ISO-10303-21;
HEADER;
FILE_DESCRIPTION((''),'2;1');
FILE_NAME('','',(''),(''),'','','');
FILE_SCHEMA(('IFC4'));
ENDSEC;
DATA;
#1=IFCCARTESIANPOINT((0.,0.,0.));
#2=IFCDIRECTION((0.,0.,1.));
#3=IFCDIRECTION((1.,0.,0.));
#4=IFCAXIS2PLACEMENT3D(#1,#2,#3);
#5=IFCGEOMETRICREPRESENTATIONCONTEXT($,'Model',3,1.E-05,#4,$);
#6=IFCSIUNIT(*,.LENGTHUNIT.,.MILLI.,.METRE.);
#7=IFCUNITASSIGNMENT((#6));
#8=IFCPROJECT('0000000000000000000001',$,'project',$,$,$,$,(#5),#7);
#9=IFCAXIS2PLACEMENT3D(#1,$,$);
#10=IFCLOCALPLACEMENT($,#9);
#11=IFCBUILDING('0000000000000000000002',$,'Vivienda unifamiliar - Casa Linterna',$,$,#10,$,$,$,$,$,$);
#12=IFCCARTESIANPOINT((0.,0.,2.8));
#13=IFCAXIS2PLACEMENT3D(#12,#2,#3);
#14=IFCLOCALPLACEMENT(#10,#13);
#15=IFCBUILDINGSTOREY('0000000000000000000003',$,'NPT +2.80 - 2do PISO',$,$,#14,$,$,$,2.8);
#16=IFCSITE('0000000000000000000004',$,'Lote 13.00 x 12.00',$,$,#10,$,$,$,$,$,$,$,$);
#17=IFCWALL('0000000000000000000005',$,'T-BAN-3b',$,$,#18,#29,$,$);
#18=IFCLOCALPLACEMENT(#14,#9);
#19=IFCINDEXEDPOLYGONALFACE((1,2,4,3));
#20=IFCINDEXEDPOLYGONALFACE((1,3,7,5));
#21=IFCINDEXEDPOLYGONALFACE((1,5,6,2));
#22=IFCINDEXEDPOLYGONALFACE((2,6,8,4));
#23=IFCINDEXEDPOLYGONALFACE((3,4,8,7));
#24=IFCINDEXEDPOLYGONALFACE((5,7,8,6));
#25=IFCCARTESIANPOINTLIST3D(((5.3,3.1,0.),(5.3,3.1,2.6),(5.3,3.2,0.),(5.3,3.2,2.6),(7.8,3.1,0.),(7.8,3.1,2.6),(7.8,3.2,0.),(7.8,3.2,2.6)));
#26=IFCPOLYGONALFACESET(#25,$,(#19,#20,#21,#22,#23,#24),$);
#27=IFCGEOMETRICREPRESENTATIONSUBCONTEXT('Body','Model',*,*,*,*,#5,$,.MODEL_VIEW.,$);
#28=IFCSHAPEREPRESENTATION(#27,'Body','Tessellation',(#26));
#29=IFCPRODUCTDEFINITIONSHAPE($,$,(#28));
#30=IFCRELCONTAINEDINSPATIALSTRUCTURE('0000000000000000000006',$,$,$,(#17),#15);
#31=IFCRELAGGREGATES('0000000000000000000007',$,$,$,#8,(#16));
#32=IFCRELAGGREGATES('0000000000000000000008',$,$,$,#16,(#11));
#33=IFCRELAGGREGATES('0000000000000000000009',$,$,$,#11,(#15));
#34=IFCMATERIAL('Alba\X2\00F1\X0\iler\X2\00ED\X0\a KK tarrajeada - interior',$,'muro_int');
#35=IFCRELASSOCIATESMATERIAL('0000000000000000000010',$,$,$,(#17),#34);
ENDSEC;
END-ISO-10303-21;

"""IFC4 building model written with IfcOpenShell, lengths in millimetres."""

from ifc_helpers import new_model, si_unit, frame, origin, origin_with_axes, place, context, subcontext, project, spatial, polyline, outline, extrude, material, element, save


model = new_model("IFC4")

# Units and contexts
model_context = context("Model", 3, precision=1e-05, world=origin_with_axes())
body_context = subcontext(model_context, "Body", "Model", "MODEL_VIEW")
ifc_project = project(units=[si_unit("LENGTHUNIT", "METRE", prefix="MILLI")], contexts=[model_context])

# Site, building, storey
placement = place(None, origin())
site = spatial("IfcSite", under=ifc_project, at=placement, Name="Lote 13.00 x 12.00")
building = spatial("IfcBuilding", under=site, at=placement, Name="Vivienda unifamiliar - Casa Linterna")
storey_placement = place(placement, frame((0.0, 0.0, 2.8), z_axis=(0.0, 0.0, 1.0), x_axis=(1.0, 0.0, 0.0)))
storey = spatial("IfcBuildingStorey", under=building, at=storey_placement, Name="NPT +2.80 - 2do PISO", Elevation=2.8)

# Shared definitions
ifc_material_1 = material(Name="Albañilería KK tarrajeada - interior", Category="muro_int")

# Wall
wall_1_placement = place(storey_placement, frame((0.0, 0.0, -2.8), z_axis=(0.0, 0.0, 1.0), x_axis=(1.0, 0.0, 0.0)))
element("IfcWall", 1, at=wall_1_placement, inside=storey, material=ifc_material_1, Name="T-BAN-3b", context=body_context, shape_type="SweptSolid", body=[
    extrude(outline(polyline([(3.1, 2.8), (3.2, 2.8), (3.2, 5.4), (3.1, 5.4), (3.1, 2.8)])), frame((5.3, 0.0, 0.0), z_axis=(1.0, 0.0, 0.0), x_axis=(0.0, 1.0, 0.0)), (0.0, 0.0, 1.0), 2.5),
])

save(model, "model.ifc")
